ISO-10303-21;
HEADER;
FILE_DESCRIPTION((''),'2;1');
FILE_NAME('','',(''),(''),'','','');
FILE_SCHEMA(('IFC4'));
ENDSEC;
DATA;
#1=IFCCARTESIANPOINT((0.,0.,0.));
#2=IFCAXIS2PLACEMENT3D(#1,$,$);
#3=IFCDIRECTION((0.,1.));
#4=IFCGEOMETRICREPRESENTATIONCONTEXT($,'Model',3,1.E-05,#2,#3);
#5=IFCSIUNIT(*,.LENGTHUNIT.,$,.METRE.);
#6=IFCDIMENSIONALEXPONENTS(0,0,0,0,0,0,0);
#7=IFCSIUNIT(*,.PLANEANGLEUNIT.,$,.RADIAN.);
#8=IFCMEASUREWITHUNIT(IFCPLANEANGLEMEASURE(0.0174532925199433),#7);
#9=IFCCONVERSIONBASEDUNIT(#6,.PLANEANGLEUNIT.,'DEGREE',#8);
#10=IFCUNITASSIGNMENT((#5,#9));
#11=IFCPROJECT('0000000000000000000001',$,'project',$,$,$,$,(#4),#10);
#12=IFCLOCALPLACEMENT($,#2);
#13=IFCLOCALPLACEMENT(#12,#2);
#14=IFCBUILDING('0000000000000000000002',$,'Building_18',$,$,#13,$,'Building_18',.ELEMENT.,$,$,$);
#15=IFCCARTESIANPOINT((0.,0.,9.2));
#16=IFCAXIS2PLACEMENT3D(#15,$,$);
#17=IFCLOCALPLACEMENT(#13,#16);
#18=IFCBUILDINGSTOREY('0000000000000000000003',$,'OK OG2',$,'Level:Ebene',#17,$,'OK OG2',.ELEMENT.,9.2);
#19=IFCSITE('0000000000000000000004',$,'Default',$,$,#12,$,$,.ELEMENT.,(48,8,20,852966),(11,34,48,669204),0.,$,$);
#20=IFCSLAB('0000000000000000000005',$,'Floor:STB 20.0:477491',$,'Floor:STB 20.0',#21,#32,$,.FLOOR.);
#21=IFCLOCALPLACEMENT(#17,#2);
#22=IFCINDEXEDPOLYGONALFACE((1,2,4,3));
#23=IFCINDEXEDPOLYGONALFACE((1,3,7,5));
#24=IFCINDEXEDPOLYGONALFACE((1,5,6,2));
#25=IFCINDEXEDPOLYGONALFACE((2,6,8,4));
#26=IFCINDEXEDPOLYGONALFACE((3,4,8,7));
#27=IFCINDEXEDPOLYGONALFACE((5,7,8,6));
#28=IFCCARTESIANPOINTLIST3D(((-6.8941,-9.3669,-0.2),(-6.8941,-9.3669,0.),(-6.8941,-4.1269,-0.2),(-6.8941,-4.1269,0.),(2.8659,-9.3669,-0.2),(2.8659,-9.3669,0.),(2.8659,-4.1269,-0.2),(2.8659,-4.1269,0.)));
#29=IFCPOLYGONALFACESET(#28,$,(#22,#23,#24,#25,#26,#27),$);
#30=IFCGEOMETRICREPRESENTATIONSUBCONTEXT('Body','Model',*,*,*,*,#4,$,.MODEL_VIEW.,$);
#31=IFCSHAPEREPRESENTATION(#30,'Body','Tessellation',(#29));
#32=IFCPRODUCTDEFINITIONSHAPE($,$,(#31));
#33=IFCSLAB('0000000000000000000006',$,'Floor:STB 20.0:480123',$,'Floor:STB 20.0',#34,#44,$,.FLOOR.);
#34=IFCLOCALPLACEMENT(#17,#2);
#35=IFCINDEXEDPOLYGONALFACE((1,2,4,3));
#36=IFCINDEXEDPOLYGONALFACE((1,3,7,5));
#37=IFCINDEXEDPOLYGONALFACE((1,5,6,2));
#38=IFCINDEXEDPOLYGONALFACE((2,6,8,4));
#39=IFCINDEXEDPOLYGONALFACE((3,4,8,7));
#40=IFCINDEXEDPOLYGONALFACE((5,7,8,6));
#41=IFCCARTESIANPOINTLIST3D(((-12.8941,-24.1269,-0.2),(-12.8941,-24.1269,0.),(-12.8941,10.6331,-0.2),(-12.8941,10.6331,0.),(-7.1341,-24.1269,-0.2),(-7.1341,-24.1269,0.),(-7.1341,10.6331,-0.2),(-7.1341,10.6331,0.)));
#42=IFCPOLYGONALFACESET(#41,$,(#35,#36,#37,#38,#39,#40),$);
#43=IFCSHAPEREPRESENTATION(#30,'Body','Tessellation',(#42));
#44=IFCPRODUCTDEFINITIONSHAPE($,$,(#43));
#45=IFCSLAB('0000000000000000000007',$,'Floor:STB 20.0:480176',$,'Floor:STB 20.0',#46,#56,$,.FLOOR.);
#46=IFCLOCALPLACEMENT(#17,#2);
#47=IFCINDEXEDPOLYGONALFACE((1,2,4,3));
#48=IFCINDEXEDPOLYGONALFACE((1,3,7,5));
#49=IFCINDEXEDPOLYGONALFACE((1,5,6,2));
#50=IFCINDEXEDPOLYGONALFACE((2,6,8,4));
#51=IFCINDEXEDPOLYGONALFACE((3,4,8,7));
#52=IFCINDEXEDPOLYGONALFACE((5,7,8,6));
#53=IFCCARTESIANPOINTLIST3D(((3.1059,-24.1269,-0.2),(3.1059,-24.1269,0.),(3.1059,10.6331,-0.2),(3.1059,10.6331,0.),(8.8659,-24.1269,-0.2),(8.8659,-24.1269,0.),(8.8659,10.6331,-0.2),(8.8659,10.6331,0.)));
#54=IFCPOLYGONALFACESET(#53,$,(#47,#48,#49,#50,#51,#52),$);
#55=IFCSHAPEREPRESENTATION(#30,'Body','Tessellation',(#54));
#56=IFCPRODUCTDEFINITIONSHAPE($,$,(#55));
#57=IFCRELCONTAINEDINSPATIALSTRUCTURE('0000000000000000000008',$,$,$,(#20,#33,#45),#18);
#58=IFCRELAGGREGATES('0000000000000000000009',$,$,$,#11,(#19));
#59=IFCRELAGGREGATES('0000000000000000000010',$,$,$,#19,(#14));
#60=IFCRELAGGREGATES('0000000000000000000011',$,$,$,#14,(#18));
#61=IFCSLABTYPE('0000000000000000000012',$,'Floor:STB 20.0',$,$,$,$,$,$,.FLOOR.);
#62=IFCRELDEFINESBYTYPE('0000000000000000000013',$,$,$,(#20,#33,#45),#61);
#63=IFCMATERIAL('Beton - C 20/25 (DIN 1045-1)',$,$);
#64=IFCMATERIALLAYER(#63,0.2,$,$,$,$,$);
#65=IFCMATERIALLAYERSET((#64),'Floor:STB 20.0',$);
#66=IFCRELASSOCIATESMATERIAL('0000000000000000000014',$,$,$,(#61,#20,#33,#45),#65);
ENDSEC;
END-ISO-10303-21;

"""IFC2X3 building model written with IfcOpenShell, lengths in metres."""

from ifc_helpers import new_model, entity, si_unit, converted_unit, direction, frame, frame_2d, origin, origin_2d_with_axis, place, context, subcontext, project, spatial, rectangle, extrude, material, layer, layer_set, layer_usage, type_object, element, save


model = new_model("IFC2X3")

# Units and contexts
model_context = context("Model", 3, precision=1e-05, world=origin(), true_north=direction((0.0, 1.0)))
body_context = subcontext(model_context, "Body", "Model", "MODEL_VIEW")
ifc_project = project(units=[si_unit("LENGTHUNIT", "METRE"), converted_unit("PLANEANGLEUNIT", "DEGREE", entity("IfcPlaneAngleMeasure", 0.0174532925199433), si_unit("PLANEANGLEUNIT", "RADIAN"), dimensions=[0, 0, 0, 0, 0, 0, 0])], contexts=[model_context])

# Site, building, storey
site_placement = place(None, origin())
site = spatial("IfcSite", under=ifc_project, at=site_placement, Name="Default", CompositionType="ELEMENT", RefLatitude=(48, 8, 20, 852966), RefLongitude=(11, 34, 48, 669204), RefElevation=0.0)
building_placement = place(site_placement, origin())
building = spatial("IfcBuilding", under=site, at=building_placement, Name="Building_18", LongName="Building_18", CompositionType="ELEMENT")
storey_placement = place(building_placement, frame((0.0, 0.0, 9.2)))
storey = spatial("IfcBuildingStorey", under=building, at=storey_placement, Name="OK OG2", ObjectType="Level:Ebene", LongName="OK OG2", CompositionType="ELEMENT", Elevation=9.2)

# Slabs
ifc_material = material(Name="Beton - C 20/25 (DIN 1045-1)")
ifc_layer = layer(ifc_material, 0.2)
ifc_layer_set = layer_set([ifc_layer], Name="Floor:STB 20.0")
ifc_layer_usage_1 = layer_usage(ifc_layer_set, "AXIS3", "POSITIVE", 0.0)
slab_type = type_object("IfcSlabType", Name="Floor:STB 20.0", PredefinedType="FLOOR", material=ifc_layer_set)
slab_1_placement = place(storey_placement, origin())
element("IfcSlab", 1, at=slab_1_placement, inside=storey, type_object=slab_type, material=ifc_layer_usage_1, Name="Floor:STB 20.0:477491", ObjectType="Floor:STB 20.0", PredefinedType="FLOOR", context=body_context, shape_type="SweptSolid", body=[
    extrude(rectangle(XDim=5.24, YDim=9.76, at=frame_2d((0.0, 0.0), x_axis=(1.0, 0.0))), frame((-2.0141, -6.7469, 0.0), z_axis=(0.0, 0.0, -1.0), x_axis=(0.0, 1.0, 0.0)), (0.0, 0.0, 1.0), 0.2),
])
ifc_layer_usage_2 = layer_usage(ifc_layer_set, "AXIS3", "POSITIVE", 0.0)
slab_2_placement = place(storey_placement, origin())
element("IfcSlab", 2, at=slab_2_placement, inside=storey, type_object=slab_type, material=ifc_layer_usage_2, Name="Floor:STB 20.0:480123", ObjectType="Floor:STB 20.0", PredefinedType="FLOOR", context=body_context, shape_type="SweptSolid", body=[
    extrude(rectangle(XDim=34.76, YDim=5.76, at=frame_2d((0.0, 0.0), x_axis=(1.0, 0.0))), frame((-10.0141, -6.7469, 0.0), z_axis=(0.0, 0.0, -1.0), x_axis=(0.0, 1.0, 0.0)), (0.0, 0.0, 1.0), 0.2),
])
ifc_layer_usage_3 = layer_usage(ifc_layer_set, "AXIS3", "POSITIVE", 0.0)
slab_3_placement = place(storey_placement, origin())
element("IfcSlab", 3, at=slab_3_placement, inside=storey, type_object=slab_type, material=ifc_layer_usage_3, Name="Floor:STB 20.0:480176", ObjectType="Floor:STB 20.0", PredefinedType="FLOOR", context=body_context, shape_type="SweptSolid", body=[
    extrude(rectangle(XDim=34.76, YDim=5.76, at=origin_2d_with_axis()), frame((5.9859, -6.7469, 0.0), z_axis=(0.0, 0.0, -1.0), x_axis=(0.0, 1.0, 0.0)), (0.0, 0.0, 1.0), 0.2),
])

save(model, "model.ifc")
